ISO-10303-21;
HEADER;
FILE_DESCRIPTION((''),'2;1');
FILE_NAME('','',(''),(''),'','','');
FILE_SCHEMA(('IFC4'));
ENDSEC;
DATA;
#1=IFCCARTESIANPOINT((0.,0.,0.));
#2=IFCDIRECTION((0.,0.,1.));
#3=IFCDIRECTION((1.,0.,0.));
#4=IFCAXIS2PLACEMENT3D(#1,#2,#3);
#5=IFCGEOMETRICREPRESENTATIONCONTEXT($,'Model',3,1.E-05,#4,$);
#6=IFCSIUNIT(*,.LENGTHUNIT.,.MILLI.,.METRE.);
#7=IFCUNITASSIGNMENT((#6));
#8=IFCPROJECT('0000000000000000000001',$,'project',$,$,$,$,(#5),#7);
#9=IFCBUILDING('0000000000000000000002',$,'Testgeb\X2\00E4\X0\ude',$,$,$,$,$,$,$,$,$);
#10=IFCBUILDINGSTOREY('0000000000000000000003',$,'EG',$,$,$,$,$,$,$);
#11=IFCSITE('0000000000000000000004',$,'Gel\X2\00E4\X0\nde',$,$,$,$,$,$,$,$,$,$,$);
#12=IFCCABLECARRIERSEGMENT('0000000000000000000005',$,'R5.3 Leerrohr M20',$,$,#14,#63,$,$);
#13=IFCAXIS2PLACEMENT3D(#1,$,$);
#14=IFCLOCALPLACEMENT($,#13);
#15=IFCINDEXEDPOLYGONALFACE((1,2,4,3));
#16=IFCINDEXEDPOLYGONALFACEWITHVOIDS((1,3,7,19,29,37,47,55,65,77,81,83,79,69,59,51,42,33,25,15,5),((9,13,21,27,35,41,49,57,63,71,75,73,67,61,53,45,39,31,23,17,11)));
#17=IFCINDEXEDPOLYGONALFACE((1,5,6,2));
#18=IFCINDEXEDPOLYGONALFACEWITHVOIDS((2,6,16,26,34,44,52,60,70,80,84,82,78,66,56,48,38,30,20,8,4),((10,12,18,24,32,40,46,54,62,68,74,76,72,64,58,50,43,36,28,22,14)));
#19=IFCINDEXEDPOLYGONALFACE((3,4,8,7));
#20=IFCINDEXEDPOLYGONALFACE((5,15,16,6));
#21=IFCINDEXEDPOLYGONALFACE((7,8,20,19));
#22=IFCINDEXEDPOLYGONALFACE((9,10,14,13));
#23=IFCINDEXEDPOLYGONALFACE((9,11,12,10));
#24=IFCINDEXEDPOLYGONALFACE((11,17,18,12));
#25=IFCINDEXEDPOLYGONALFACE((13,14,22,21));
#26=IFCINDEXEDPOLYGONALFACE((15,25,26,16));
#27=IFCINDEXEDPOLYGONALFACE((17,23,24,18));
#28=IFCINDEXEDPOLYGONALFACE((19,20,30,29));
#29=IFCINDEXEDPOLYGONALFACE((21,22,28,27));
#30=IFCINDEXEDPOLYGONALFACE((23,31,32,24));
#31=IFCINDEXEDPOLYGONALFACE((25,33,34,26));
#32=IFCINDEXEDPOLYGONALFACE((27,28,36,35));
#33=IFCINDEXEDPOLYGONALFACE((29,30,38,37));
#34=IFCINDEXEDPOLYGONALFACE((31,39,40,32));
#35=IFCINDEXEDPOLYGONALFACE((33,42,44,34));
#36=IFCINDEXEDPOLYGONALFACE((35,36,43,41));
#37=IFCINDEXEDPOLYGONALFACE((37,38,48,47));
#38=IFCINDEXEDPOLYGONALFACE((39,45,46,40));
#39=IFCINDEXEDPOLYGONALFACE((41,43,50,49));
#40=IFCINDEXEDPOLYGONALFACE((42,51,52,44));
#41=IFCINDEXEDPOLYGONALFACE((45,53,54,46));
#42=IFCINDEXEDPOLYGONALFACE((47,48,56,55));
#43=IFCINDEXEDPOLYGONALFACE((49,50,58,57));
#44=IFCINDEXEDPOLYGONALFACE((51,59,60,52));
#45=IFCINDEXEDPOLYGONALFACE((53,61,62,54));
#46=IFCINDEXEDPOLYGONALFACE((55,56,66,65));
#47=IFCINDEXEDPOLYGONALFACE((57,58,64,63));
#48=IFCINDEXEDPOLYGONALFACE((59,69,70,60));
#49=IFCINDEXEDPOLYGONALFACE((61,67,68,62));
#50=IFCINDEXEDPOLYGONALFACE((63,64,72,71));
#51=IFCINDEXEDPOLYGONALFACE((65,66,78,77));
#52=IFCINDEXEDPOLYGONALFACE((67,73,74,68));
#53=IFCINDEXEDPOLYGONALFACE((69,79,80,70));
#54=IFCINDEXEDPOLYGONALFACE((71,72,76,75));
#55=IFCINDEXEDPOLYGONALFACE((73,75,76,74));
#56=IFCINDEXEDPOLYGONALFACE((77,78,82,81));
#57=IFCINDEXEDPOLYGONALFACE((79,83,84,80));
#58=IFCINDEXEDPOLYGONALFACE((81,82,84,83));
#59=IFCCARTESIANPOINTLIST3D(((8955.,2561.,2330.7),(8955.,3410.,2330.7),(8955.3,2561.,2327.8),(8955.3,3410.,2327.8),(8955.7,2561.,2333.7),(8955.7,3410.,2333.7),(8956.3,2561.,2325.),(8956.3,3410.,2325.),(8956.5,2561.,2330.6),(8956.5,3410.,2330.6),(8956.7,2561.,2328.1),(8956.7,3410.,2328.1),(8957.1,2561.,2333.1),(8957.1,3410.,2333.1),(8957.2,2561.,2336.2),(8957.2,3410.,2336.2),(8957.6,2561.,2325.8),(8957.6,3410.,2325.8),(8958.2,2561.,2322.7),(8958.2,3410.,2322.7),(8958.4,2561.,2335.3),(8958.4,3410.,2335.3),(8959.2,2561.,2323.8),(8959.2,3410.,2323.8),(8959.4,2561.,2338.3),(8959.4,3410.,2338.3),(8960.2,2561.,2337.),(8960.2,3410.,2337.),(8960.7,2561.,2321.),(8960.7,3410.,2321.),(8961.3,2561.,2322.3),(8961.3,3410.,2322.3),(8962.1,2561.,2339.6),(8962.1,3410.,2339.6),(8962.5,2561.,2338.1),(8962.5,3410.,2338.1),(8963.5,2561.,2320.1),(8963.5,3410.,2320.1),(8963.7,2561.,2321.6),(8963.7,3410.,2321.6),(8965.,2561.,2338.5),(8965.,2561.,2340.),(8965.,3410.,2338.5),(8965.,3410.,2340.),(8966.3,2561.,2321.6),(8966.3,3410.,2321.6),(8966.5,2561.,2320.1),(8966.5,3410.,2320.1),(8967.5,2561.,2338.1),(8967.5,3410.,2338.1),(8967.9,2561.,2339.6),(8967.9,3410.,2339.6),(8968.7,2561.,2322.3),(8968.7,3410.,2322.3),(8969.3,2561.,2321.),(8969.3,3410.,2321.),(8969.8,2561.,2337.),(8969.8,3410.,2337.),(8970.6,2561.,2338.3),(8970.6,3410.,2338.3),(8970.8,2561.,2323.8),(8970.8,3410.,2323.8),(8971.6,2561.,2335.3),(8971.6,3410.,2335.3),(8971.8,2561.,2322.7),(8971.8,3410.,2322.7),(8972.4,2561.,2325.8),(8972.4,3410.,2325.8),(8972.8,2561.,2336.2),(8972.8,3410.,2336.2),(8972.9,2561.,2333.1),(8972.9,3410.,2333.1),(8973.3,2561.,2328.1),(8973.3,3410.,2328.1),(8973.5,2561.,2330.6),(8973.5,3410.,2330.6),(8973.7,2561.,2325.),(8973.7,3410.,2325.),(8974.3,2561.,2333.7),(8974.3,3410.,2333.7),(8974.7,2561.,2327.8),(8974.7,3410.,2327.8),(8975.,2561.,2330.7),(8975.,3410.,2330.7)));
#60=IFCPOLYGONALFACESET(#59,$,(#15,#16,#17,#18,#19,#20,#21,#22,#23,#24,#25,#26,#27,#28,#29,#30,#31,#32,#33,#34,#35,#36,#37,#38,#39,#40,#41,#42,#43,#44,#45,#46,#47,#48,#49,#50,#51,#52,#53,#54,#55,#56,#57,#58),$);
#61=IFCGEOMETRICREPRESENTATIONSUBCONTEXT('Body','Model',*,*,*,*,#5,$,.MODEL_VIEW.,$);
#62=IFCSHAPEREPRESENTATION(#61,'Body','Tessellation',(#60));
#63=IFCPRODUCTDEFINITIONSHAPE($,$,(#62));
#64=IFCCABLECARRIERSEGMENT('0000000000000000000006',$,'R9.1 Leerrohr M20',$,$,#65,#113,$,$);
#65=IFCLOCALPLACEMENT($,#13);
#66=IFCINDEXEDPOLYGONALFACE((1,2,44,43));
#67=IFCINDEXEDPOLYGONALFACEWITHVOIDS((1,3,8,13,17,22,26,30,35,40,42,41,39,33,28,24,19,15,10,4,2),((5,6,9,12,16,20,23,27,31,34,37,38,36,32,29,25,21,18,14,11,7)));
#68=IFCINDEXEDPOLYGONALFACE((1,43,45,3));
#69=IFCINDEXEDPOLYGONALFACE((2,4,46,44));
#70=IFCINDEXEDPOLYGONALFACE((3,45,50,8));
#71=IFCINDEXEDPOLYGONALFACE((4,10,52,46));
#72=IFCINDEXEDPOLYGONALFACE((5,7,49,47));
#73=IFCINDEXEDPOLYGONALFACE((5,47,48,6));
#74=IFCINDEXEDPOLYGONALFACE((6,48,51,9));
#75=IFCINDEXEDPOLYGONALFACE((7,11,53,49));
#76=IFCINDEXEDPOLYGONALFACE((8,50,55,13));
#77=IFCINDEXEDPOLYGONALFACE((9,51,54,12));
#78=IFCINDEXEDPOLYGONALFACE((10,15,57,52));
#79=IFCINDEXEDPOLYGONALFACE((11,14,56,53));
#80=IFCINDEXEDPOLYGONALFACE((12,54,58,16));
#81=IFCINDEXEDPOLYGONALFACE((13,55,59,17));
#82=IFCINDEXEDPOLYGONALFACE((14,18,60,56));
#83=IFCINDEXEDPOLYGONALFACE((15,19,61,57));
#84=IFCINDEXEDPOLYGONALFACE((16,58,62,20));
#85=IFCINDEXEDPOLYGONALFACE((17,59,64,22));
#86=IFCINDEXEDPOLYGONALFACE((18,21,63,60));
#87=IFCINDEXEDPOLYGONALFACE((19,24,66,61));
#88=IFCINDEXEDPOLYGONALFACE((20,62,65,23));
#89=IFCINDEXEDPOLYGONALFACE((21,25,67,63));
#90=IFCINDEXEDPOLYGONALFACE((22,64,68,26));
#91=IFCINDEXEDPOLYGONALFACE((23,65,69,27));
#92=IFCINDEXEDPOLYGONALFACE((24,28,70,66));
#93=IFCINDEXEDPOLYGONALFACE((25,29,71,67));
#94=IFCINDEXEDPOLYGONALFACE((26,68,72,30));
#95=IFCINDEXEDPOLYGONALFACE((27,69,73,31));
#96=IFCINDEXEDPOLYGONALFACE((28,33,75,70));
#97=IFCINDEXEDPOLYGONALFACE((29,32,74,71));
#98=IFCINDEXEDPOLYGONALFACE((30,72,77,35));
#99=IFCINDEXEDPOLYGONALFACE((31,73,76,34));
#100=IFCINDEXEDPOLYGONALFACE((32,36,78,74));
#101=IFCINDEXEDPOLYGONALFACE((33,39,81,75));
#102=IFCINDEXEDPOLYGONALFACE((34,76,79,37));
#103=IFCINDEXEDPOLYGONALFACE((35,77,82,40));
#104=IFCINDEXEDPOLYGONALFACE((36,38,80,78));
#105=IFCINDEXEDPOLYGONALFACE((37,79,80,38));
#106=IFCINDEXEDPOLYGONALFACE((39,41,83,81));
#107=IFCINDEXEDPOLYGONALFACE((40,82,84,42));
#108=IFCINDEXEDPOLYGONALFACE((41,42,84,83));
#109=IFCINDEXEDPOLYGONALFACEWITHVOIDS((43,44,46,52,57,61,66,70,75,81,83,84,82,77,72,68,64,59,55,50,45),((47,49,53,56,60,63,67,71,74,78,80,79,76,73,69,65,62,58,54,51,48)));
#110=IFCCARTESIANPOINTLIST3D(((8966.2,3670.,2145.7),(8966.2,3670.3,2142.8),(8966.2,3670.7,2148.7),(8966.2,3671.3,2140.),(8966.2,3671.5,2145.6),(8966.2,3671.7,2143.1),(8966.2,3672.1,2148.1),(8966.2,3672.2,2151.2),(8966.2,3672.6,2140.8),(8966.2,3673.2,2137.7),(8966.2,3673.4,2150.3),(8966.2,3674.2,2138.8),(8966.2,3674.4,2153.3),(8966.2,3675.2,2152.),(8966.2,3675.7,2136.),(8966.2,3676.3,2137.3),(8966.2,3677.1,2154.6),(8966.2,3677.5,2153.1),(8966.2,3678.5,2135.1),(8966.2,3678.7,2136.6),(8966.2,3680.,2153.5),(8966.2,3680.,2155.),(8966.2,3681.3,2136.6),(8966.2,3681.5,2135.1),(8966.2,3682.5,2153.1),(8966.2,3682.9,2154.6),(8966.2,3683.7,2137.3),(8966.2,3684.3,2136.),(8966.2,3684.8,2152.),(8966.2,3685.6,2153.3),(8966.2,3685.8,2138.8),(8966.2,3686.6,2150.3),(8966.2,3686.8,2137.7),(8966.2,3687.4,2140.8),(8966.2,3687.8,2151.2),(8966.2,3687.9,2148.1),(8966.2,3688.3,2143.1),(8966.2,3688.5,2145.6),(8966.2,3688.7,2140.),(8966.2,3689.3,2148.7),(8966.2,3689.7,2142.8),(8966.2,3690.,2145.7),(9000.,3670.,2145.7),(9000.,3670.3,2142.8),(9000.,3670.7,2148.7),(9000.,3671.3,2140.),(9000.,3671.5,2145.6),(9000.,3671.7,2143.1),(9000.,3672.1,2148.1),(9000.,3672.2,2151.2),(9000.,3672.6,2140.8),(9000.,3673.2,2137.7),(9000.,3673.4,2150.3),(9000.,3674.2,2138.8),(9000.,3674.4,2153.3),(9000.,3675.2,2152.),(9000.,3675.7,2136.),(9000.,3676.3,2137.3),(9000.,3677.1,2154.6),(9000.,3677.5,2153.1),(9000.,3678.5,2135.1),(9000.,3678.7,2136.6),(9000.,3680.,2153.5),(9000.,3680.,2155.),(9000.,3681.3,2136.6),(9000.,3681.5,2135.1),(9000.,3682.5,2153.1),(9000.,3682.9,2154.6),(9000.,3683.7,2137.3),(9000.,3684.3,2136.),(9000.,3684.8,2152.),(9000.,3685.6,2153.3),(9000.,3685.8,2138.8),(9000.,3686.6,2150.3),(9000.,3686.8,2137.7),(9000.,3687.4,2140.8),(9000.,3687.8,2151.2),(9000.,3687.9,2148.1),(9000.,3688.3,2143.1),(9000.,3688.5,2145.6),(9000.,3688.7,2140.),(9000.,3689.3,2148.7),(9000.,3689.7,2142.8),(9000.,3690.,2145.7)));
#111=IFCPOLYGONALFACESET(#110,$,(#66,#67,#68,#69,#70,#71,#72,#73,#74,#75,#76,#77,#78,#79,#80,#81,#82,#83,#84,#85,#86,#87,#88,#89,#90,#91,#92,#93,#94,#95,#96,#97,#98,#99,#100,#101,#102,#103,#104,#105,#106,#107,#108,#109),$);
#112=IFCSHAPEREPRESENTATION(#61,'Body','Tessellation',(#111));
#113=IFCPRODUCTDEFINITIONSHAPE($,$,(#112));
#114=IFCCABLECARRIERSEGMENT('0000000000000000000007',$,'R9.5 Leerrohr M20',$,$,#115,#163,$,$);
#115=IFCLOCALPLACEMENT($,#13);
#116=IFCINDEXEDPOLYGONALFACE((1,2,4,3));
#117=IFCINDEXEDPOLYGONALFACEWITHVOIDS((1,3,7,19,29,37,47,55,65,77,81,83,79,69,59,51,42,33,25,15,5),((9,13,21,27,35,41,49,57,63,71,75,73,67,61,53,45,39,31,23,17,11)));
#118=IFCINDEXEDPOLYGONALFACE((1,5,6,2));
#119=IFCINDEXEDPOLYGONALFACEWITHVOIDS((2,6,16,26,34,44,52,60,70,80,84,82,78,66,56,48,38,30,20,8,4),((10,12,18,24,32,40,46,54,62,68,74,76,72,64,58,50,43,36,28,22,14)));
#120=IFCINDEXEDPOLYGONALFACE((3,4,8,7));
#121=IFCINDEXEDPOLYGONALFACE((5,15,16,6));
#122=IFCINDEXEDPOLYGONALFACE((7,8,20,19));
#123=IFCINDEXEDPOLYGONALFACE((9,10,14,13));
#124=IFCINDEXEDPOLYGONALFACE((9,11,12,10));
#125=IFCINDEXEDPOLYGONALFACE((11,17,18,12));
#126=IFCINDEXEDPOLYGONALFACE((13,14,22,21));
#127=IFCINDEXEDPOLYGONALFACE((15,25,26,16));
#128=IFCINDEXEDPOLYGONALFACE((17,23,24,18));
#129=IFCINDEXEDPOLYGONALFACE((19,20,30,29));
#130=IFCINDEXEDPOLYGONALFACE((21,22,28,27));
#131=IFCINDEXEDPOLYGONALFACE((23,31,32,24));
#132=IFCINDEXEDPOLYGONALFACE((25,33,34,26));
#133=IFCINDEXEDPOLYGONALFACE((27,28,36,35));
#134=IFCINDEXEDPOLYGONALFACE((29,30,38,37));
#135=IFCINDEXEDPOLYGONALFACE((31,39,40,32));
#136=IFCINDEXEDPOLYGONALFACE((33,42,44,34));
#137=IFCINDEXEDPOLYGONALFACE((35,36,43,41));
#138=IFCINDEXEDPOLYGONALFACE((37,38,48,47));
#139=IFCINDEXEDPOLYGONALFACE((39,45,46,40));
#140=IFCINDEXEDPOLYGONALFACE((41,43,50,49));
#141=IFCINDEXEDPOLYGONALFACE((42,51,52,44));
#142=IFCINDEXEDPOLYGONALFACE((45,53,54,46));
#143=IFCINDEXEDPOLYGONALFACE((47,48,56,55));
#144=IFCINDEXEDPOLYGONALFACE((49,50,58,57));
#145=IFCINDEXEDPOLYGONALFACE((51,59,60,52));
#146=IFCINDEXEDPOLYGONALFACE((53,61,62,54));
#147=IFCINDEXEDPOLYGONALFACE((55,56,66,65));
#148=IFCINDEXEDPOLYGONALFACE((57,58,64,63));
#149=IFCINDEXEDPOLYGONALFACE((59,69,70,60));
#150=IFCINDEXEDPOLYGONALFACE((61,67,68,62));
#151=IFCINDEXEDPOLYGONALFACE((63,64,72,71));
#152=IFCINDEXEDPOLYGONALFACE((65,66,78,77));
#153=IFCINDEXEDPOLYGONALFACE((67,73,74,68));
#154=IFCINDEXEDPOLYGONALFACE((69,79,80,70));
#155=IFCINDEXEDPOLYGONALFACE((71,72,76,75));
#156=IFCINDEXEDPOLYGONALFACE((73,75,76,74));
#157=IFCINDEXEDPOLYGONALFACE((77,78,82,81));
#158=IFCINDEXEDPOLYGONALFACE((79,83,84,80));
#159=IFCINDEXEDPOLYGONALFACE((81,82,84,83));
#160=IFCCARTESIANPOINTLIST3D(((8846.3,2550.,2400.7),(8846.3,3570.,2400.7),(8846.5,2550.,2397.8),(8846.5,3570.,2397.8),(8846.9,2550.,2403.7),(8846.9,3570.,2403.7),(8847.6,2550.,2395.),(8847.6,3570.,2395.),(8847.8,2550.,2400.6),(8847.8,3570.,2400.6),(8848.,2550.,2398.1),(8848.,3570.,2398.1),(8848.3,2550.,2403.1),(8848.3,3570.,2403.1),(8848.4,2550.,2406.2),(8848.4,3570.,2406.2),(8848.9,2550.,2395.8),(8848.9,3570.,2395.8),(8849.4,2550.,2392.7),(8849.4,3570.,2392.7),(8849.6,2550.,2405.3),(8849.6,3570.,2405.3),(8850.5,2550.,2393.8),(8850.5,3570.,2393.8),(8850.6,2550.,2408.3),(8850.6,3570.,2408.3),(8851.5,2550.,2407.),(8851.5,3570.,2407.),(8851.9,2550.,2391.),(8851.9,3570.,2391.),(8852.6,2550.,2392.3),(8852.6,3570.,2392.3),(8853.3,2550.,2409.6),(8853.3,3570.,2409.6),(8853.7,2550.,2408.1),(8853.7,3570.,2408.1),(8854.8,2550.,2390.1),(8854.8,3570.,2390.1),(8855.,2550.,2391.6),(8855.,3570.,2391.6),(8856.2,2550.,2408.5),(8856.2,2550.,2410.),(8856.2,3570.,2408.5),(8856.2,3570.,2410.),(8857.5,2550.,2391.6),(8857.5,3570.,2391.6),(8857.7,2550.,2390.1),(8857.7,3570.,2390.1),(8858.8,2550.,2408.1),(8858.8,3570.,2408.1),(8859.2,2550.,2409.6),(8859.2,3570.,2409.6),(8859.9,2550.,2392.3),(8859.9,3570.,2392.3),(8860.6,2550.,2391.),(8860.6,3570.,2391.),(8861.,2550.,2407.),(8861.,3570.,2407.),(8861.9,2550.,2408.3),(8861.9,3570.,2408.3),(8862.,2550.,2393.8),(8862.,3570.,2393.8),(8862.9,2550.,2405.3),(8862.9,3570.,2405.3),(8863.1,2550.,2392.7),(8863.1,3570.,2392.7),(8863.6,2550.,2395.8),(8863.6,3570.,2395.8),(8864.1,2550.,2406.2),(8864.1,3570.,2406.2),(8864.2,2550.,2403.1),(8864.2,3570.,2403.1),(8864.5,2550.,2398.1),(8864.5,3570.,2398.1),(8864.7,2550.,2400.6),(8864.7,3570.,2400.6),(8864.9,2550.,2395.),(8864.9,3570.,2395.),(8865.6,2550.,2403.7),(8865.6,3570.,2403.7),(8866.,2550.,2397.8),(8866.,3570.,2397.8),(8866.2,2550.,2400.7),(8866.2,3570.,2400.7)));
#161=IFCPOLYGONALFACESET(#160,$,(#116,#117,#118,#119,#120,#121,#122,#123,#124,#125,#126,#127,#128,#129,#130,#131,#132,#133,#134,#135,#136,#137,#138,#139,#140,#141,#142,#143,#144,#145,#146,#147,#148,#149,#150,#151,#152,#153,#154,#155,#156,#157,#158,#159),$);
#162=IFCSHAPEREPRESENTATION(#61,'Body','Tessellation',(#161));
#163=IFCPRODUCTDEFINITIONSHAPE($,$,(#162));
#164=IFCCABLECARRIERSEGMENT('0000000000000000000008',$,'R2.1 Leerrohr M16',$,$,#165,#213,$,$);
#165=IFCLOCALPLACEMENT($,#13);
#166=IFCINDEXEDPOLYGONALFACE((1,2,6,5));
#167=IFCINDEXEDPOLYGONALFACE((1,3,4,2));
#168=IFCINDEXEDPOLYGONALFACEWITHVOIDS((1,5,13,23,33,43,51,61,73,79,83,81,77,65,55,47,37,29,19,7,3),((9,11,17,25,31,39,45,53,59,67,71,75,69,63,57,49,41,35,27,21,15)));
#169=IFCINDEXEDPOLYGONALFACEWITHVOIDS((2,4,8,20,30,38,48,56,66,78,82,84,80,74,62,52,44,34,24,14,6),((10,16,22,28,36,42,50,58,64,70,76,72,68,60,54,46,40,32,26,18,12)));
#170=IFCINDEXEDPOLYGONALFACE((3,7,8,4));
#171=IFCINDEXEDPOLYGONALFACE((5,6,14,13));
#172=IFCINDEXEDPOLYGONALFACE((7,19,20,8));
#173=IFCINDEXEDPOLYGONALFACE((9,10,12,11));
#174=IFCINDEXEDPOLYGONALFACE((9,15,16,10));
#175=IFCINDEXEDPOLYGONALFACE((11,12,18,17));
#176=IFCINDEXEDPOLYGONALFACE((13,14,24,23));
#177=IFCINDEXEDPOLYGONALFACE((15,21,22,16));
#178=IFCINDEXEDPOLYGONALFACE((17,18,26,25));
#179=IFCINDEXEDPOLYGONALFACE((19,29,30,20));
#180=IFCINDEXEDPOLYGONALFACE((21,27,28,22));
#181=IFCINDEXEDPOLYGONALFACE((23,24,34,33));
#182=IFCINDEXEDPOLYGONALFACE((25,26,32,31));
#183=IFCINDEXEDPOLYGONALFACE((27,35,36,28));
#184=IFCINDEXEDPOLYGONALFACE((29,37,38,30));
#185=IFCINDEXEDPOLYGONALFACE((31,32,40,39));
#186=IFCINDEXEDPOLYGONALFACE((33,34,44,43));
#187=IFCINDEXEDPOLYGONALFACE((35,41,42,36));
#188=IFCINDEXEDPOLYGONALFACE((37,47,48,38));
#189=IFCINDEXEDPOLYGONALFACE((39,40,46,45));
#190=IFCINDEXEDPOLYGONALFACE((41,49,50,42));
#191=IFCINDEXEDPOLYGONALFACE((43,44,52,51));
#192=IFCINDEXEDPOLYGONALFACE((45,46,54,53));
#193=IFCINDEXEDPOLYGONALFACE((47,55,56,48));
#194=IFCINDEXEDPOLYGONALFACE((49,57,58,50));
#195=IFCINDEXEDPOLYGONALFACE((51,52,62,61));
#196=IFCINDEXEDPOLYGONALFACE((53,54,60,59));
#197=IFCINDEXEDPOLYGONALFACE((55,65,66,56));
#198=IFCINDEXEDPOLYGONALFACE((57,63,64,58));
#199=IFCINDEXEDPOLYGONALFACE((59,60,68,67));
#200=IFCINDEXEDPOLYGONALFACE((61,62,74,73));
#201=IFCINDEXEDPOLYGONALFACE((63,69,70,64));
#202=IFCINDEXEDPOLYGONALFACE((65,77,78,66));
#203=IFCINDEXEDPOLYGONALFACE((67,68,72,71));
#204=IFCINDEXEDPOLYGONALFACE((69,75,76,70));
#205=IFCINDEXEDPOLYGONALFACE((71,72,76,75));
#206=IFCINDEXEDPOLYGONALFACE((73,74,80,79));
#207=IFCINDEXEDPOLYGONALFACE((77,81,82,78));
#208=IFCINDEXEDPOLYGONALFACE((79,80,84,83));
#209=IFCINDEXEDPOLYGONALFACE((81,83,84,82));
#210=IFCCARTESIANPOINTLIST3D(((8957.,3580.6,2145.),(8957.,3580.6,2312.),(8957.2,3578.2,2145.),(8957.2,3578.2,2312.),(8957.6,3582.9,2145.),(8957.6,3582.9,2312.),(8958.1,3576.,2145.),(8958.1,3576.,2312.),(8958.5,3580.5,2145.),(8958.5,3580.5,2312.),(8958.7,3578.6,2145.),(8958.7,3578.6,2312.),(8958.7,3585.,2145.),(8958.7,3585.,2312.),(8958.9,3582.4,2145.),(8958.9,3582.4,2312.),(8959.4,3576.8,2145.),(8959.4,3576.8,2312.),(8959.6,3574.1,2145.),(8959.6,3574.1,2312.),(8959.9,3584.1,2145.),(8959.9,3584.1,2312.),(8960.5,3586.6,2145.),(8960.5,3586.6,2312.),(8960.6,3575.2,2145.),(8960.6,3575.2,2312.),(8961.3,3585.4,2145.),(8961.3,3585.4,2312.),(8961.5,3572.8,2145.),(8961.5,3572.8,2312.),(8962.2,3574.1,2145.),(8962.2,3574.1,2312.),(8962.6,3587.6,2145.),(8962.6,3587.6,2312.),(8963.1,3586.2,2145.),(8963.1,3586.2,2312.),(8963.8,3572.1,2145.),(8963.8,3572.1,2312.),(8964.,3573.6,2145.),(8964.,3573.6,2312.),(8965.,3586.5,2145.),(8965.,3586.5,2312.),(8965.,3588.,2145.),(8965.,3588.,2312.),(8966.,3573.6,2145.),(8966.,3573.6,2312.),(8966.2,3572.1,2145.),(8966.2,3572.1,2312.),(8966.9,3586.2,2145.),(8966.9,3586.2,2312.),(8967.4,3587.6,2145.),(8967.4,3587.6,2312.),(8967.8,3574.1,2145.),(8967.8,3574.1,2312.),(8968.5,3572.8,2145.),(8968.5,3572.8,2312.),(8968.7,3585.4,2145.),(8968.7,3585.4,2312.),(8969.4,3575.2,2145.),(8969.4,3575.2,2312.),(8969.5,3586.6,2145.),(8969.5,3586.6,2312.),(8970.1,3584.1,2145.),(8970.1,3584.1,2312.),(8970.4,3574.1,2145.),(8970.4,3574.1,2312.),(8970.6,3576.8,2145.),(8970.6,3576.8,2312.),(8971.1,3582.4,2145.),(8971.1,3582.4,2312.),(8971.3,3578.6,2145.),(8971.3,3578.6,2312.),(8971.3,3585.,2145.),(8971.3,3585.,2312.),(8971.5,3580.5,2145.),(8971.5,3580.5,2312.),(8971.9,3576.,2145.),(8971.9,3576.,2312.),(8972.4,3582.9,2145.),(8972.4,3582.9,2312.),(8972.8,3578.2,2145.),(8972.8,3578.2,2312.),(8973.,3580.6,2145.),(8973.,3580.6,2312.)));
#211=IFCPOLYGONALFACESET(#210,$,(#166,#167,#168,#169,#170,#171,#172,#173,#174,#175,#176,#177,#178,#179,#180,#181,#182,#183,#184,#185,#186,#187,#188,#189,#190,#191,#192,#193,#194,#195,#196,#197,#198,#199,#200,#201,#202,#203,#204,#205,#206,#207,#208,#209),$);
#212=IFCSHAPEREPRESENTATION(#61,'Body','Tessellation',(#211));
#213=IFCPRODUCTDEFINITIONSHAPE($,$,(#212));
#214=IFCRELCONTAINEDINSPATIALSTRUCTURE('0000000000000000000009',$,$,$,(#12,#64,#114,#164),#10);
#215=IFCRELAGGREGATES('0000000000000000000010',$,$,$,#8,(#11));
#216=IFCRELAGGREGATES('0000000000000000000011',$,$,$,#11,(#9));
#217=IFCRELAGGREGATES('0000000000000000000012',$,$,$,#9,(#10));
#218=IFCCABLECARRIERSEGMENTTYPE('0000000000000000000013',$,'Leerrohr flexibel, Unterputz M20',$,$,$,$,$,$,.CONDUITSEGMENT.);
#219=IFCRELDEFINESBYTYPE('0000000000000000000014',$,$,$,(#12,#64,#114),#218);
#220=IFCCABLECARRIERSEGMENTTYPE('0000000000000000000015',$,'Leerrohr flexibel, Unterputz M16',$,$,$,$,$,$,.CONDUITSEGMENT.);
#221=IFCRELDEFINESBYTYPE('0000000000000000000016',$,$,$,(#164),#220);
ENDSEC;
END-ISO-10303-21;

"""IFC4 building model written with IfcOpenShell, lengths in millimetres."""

from ifc_helpers import new_model, si_unit, frame, origin_with_axes, place, context, subcontext, project, spatial, hollow_circle, extrude, type_object, element, save


model = new_model("IFC4")

# Units and contexts
model_context = context("Model", 3, precision=1e-05, world=origin_with_axes())
body_context = subcontext(model_context, "Body", "Model", "MODEL_VIEW")
ifc_project = project(units=[si_unit("LENGTHUNIT", "METRE", prefix="MILLI")], contexts=[model_context])

# Site, building, storey
site = spatial("IfcSite", under=ifc_project, Name="Gelände")
building = spatial("IfcBuilding", under=site, Name="Testgebäude")
storey = spatial("IfcBuildingStorey", under=building, Name="EG")

# Cable carrier segments
cable_carrier_segment_type_1 = type_object("IfcCableCarrierSegmentType", Name="Leerrohr flexibel, Unterputz M20", PredefinedType="CONDUITSEGMENT")
cable_carrier_segment_1_placement = place(None, frame((8965.0, 3410.0, 2330.0), z_axis=(0.0, -1.0, 0.0), x_axis=(0.0, 0.0, 1.0)))
element("IfcCableCarrierSegment", 1, at=cable_carrier_segment_1_placement, inside=storey, type_object=cable_carrier_segment_type_1, Name="R5.3 Leerrohr M20", context=body_context, shape_type="SweptSolid", body=[
    extrude(hollow_circle(Radius=10.0, WallThickness=1.5), None, (0.0, 0.0, 1.0), 849.0),
])
cable_carrier_segment_2_placement = place(None, frame((9000.0, 3680.0, 2145.0), z_axis=(-1.0, 0.0, 0.0), x_axis=(0.0, 0.0, 1.0)))
element("IfcCableCarrierSegment", 2, at=cable_carrier_segment_2_placement, inside=storey, type_object=cable_carrier_segment_type_1, Name="R9.1 Leerrohr M20", context=body_context, shape_type="SweptSolid", body=[
    extrude(hollow_circle(Radius=10.0, WallThickness=1.5), None, (0.0, 0.0, 1.0), 33.8),
])
cable_carrier_segment_3_placement = place(None, frame((8856.2, 3570.0, 2400.0), z_axis=(0.0, -1.0, 0.0), x_axis=(0.0, 0.0, 1.0)))
element("IfcCableCarrierSegment", 3, at=cable_carrier_segment_3_placement, inside=storey, type_object=cable_carrier_segment_type_1, Name="R9.5 Leerrohr M20", context=body_context, shape_type="SweptSolid", body=[
    extrude(hollow_circle(Radius=10.0, WallThickness=1.5), None, (0.0, 0.0, 1.0), 1020.0),
])

# Cable carrier segment
cable_carrier_segment_type_2 = type_object("IfcCableCarrierSegmentType", Name="Leerrohr flexibel, Unterputz M16", PredefinedType="CONDUITSEGMENT")
cable_carrier_segment_4_placement = place(None, frame((8965.0, 3580.0, 2145.0), z_axis=(0.0, 0.0, 1.0), x_axis=(0.0, 1.0, 0.0)))
element("IfcCableCarrierSegment", 4, at=cable_carrier_segment_4_placement, inside=storey, type_object=cable_carrier_segment_type_2, Name="R2.1 Leerrohr M16", context=body_context, shape_type="SweptSolid", body=[
    extrude(hollow_circle(Radius=8.0, WallThickness=1.5), None, (0.0, 0.0, 1.0), 167.0),
])

save(model, "model.ifc")
